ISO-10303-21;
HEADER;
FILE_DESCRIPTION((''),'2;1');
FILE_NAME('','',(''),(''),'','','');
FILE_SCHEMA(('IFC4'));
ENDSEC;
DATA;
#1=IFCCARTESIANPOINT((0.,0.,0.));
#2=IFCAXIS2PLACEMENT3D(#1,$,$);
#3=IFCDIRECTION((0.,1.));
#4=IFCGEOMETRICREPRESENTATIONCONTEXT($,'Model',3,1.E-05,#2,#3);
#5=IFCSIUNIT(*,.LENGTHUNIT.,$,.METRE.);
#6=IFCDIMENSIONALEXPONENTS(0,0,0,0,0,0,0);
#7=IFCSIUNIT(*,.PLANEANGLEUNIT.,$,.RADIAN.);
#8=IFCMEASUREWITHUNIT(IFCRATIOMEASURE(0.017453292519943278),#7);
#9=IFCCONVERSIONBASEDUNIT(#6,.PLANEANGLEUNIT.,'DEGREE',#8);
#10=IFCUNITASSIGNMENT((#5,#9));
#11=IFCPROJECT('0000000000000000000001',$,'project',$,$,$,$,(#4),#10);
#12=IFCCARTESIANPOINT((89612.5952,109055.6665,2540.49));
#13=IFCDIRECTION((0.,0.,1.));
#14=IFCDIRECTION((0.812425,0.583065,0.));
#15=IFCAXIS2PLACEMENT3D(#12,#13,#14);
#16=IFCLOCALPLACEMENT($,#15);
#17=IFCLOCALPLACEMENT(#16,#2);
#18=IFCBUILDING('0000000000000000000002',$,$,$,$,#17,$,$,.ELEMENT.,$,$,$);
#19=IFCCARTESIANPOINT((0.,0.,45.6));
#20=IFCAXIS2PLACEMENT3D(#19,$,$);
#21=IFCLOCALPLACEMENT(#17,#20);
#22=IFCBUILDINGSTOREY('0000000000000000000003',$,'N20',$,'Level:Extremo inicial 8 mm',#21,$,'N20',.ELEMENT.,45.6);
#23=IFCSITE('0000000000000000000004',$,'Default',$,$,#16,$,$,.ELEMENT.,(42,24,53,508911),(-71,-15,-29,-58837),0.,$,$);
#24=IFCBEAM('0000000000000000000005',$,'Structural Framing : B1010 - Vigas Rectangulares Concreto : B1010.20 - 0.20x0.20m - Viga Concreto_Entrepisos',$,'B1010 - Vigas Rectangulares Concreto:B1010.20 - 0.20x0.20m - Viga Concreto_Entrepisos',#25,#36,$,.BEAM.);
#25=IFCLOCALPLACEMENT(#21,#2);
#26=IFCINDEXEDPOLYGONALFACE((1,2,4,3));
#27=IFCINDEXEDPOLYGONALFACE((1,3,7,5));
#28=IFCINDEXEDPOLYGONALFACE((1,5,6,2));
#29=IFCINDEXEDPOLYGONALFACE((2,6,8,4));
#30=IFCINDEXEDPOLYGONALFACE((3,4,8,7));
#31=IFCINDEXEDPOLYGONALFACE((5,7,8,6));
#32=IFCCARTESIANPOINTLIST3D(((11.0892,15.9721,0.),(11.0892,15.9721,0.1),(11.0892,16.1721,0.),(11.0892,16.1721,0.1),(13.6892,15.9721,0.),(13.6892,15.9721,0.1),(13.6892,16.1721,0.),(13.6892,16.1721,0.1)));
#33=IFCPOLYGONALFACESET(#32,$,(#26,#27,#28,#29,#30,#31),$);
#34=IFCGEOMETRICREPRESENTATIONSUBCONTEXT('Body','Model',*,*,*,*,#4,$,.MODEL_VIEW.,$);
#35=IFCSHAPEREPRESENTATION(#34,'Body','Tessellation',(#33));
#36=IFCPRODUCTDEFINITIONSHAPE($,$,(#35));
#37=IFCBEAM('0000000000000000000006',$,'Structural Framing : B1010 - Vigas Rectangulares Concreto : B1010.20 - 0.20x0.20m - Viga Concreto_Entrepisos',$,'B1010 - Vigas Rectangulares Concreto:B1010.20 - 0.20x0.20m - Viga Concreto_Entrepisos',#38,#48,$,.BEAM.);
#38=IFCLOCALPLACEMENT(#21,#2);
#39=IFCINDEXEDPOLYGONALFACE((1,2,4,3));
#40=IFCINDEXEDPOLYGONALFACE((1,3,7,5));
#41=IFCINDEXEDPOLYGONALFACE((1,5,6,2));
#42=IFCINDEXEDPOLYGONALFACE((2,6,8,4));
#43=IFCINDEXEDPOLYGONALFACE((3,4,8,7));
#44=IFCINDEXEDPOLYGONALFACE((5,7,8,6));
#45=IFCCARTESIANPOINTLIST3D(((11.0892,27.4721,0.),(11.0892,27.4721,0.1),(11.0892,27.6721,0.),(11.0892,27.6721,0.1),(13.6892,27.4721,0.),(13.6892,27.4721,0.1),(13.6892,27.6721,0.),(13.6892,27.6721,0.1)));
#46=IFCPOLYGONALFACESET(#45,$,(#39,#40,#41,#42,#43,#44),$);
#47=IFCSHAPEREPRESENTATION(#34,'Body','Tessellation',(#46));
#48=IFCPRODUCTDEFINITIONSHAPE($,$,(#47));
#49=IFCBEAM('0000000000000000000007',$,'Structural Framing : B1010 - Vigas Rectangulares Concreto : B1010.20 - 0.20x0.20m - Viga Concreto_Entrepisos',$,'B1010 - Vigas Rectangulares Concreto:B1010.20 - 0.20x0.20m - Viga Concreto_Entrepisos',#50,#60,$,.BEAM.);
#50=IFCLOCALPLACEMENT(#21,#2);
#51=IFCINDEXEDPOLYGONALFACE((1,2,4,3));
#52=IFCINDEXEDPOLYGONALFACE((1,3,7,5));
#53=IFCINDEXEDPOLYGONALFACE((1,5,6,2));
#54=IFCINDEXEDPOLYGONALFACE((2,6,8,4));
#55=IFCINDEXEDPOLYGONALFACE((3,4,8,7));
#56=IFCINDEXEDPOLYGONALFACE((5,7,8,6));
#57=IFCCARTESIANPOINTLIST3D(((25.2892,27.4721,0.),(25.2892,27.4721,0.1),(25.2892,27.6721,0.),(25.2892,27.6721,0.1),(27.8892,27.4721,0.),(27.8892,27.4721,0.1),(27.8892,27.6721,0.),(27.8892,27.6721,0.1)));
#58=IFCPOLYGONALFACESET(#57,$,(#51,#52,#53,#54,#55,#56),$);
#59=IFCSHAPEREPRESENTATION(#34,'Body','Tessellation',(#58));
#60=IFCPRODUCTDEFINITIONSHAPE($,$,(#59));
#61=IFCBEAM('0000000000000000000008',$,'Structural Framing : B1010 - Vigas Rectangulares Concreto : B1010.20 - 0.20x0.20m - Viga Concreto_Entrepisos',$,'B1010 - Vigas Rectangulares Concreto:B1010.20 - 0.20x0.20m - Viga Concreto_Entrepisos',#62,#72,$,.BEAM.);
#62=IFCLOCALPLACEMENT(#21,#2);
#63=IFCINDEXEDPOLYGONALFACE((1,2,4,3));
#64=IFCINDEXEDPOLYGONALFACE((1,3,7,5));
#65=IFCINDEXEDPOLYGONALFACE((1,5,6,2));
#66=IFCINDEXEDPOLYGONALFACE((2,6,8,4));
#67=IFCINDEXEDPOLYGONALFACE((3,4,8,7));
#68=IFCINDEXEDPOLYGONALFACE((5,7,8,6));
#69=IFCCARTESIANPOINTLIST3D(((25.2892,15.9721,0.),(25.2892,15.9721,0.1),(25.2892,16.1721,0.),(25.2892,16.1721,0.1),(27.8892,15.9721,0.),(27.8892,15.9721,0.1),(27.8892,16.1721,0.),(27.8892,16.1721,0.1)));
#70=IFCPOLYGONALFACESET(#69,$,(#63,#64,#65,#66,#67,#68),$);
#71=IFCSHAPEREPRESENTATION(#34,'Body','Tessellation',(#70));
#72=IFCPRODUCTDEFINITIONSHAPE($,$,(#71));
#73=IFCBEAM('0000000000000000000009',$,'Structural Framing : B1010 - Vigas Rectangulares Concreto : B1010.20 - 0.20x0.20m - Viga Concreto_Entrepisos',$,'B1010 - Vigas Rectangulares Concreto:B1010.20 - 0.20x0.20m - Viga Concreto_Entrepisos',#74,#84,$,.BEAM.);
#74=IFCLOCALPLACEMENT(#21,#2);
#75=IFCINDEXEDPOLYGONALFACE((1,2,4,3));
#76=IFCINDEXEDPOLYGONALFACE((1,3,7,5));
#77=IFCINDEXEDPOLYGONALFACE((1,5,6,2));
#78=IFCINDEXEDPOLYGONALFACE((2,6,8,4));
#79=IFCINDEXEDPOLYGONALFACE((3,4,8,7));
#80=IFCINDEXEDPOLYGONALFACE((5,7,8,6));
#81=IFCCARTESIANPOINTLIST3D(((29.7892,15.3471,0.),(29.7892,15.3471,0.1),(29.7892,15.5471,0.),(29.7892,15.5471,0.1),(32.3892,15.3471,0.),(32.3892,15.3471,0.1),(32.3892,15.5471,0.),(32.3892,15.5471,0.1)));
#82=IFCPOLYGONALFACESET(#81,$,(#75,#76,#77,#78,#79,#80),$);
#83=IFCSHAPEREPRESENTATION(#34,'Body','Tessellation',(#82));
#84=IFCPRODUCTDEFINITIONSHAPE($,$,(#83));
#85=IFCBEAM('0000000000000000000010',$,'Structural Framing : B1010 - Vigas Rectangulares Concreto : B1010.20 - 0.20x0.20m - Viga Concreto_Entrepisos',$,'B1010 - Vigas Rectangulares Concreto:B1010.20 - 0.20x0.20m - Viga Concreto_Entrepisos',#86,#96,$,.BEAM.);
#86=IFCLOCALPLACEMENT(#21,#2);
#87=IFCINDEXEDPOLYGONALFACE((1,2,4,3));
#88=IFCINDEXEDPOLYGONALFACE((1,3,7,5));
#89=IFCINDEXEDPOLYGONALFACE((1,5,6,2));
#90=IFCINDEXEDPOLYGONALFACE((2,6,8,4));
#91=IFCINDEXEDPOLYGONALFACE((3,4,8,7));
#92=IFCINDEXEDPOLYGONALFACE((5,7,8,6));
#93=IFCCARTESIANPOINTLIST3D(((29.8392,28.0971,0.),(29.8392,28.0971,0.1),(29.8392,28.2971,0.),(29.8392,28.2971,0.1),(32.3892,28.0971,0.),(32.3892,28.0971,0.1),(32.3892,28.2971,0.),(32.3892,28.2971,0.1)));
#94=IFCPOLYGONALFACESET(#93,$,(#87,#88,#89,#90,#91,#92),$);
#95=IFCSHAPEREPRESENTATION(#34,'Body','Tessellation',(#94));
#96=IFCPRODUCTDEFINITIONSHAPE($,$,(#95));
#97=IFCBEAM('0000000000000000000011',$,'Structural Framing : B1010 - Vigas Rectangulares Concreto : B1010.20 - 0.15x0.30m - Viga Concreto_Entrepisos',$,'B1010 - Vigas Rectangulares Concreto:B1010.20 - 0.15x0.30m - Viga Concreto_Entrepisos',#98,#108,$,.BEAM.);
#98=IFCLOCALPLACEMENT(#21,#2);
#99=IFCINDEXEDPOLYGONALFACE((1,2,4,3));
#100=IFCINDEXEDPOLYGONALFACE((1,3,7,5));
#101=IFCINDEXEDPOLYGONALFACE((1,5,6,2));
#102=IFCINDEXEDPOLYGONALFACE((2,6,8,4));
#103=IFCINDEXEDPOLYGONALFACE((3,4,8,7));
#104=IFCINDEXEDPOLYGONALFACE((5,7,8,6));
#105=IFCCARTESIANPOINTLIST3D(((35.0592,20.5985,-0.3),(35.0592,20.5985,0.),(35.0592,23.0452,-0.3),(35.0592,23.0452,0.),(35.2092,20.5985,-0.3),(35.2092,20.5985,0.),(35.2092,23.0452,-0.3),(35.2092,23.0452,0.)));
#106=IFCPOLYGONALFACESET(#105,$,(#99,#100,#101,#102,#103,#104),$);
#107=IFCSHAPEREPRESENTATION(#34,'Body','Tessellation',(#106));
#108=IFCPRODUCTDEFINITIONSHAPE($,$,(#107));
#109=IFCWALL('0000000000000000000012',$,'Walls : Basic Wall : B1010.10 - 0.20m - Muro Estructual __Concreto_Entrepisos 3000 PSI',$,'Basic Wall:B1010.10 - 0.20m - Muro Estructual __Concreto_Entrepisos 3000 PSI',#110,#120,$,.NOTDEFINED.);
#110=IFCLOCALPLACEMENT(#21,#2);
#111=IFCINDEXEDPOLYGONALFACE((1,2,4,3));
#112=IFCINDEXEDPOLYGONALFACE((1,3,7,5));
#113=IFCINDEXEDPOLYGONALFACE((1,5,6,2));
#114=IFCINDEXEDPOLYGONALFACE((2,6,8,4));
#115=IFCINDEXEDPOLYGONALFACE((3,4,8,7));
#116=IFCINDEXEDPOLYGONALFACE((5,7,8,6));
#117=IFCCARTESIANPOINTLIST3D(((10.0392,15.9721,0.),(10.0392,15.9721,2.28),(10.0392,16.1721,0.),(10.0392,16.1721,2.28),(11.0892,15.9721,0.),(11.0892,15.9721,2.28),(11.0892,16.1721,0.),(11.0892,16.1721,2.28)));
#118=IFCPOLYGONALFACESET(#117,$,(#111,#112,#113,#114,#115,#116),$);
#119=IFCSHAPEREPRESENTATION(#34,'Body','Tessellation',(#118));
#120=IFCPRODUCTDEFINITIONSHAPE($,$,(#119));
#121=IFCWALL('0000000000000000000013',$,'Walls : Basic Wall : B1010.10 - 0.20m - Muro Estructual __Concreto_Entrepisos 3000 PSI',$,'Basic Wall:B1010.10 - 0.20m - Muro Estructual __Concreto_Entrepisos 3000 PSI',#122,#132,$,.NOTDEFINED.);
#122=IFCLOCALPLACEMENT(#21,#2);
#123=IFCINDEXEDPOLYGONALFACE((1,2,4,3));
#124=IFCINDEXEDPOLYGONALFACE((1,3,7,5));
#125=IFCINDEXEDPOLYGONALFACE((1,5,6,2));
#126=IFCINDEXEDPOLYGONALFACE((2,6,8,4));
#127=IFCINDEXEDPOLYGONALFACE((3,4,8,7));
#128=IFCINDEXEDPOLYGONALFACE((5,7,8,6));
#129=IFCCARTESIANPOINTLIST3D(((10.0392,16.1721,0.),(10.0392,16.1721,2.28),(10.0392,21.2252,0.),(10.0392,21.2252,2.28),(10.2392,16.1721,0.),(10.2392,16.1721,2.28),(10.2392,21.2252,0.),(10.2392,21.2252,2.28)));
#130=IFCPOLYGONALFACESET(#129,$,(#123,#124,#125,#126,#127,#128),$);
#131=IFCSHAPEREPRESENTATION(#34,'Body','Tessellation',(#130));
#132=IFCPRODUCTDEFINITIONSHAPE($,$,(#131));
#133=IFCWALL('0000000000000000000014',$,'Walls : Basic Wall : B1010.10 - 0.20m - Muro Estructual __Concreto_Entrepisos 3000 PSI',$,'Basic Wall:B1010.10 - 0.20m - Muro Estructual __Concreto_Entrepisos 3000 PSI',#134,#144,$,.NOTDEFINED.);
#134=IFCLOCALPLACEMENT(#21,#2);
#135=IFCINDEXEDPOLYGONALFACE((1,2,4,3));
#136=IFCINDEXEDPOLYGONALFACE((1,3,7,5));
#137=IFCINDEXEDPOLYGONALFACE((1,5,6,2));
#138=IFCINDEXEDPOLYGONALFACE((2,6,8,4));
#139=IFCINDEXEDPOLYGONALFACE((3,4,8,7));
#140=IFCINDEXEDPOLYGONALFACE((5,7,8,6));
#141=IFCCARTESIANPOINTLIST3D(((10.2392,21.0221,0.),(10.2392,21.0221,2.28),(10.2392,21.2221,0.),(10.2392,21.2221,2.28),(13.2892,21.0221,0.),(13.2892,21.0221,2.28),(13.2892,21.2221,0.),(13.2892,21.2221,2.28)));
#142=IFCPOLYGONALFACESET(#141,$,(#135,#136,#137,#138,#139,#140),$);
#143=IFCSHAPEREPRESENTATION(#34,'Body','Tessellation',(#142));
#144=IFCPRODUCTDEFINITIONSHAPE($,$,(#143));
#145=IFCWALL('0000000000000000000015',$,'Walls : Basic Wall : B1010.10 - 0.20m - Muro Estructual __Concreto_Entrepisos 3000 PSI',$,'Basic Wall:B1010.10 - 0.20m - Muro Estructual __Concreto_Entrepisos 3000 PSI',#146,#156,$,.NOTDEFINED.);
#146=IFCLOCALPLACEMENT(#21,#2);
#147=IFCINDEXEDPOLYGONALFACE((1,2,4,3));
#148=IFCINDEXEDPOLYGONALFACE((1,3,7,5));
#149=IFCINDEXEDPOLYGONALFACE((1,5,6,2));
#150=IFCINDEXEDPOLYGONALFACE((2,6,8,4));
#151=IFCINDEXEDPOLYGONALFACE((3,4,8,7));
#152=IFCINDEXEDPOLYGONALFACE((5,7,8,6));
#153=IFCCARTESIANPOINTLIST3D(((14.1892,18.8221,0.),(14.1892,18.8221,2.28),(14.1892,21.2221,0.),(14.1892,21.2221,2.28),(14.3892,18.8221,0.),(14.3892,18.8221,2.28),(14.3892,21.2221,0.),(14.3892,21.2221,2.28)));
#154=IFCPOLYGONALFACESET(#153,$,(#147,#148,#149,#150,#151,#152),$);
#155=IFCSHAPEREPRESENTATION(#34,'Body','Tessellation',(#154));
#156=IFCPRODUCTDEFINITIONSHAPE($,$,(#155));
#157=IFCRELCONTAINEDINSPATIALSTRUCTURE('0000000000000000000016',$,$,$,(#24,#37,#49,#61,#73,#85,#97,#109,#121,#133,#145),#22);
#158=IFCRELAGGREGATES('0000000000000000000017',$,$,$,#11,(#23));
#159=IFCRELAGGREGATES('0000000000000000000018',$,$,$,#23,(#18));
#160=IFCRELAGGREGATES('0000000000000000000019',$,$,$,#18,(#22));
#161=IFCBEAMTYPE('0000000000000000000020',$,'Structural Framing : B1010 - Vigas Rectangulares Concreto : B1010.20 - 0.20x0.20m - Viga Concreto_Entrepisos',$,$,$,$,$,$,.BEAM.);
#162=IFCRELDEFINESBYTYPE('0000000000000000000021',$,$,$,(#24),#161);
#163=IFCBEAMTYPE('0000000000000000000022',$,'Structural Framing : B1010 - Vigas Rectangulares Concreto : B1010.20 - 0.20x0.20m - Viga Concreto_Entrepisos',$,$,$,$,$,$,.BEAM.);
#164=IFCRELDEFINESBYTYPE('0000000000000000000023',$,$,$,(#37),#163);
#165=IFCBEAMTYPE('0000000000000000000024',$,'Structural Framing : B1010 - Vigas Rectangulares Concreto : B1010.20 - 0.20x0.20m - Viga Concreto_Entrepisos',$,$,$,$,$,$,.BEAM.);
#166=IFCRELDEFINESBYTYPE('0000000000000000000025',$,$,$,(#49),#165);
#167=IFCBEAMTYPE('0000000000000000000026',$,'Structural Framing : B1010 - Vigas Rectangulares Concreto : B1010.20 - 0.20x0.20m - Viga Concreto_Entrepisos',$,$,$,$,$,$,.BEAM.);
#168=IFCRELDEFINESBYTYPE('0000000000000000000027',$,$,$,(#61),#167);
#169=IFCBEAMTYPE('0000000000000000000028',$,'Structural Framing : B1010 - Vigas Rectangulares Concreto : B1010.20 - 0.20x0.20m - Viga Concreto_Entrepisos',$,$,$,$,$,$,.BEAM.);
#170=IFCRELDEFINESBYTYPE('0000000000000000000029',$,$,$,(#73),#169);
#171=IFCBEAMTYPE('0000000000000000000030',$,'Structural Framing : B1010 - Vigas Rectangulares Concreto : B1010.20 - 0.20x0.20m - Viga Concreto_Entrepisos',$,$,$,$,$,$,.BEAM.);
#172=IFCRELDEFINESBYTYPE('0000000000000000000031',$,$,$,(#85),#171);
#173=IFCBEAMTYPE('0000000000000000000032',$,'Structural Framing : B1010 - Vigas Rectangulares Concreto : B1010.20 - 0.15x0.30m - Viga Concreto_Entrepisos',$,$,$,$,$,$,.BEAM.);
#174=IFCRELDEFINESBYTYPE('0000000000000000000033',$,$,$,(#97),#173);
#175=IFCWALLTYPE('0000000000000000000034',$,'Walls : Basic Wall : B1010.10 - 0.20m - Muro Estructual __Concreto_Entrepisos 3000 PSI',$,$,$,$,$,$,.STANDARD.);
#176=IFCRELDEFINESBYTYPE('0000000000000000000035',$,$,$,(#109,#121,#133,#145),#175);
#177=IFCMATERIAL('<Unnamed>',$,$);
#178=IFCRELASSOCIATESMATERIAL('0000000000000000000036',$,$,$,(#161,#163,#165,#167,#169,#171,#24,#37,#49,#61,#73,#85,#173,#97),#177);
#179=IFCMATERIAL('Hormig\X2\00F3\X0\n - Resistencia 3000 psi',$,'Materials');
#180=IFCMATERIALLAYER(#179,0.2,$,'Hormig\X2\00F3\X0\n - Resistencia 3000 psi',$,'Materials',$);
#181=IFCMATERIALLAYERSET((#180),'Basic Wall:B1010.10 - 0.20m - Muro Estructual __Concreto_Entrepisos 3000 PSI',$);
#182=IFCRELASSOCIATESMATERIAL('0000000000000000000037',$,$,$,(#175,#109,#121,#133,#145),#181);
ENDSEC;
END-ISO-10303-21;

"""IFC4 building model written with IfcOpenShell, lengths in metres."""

from ifc_helpers import new_model, entity, si_unit, converted_unit, direction, frame, frame_2d, origin, place, context, subcontext, project, spatial, polyline, segment, composite_curve, rectangle, outline, extrude, source, transform, mapped, material, layer, layer_set, layer_usage, material_profile, profile_set, profile_usage, type_object, type_shapes, element, save


model = new_model("IFC4")

# Units and contexts
model_context = context("Model", 3, precision=1e-05, world=origin(), true_north=direction((0.0, 1.0)))
body_context = subcontext(model_context, "Body", "Model", "MODEL_VIEW")
ifc_project = project(units=[si_unit("LENGTHUNIT", "METRE"), converted_unit("PLANEANGLEUNIT", "DEGREE", entity("IfcRatioMeasure", 0.017453292519943278), si_unit("PLANEANGLEUNIT", "RADIAN"), dimensions=[0, 0, 0, 0, 0, 0, 0])], contexts=[model_context])

# Site, building, storey
site_placement = place(None, frame((89612.5952, 109055.6665, 2540.49), z_axis=(0.0, 0.0, 1.0), x_axis=(0.812425, 0.583065, 0.0)))
site = spatial("IfcSite", under=ifc_project, at=site_placement, Name="Default", CompositionType="ELEMENT", RefLatitude=(42, 24, 53, 508911), RefLongitude=(-71, -15, -29, -58837), RefElevation=0.0)
building_placement = place(site_placement, origin())
building = spatial("IfcBuilding", under=site, at=building_placement, CompositionType="ELEMENT")
storey_placement = place(building_placement, frame((0.0, 0.0, 45.6)))
storey = spatial("IfcBuildingStorey", under=building, at=storey_placement, Name="N20", ObjectType="Level:Extremo inicial 8 mm", LongName="N20", CompositionType="ELEMENT", Elevation=45.6)

# Beams
ifc_material_1 = material(Name="<Unnamed>")
ifc_material_profile_1 = material_profile(ifc_material_1, outline(composite_curve([segment(polyline([(-0.1, 0.0, 0.0), (-0.1, 0.1, 0.0)]), True, "CONTINUOUS"), segment(polyline([(-0.1, 0.1, 0.0), (0.1, 0.1, 0.0)]), True, "CONTINUOUS"), segment(polyline([(0.1, 0.1, 0.0), (0.1, 0.0, 0.0)]), True, "CONTINUOUS"), segment(polyline([(0.1, 0.0, 0.0), (-0.1, 0.0, 0.0)]), True, "CONTINUOUS")], self_intersect=False), kind="CURVE"), Name="B1010.20 - 0.20x0.20m - Viga Concreto_Entrepisos")
ifc_material_profile_2 = material_profile(ifc_material_1, outline(composite_curve([segment(polyline([(-1.3, -0.1, 0.1), (-1.3, 0.1, 0.1)]), True, "CONTINUOUS"), segment(polyline([(-1.3, 0.1, 0.1), (-1.3, 0.1, -0.1)]), True, "CONTINUOUS"), segment(polyline([(-1.3, 0.1, -0.1), (-1.3, -0.1, -0.1)]), True, "CONTINUOUS"), segment(polyline([(-1.3, -0.1, -0.1), (-1.3, -0.1, 0.1)]), True, "CONTINUOUS")], self_intersect=False), kind="CURVE"), Name="B1010.20 - 0.20x0.20m - Viga Concreto_Entrepisos")
ifc_profile_set_1 = profile_set([ifc_material_profile_1, ifc_material_profile_2], Name="B1010.20 - 0.20x0.20m - Viga Concreto_Entrepisos")
ifc_profile_usage_1 = profile_usage(ifc_profile_set_1, cardinal=8)
beam_type_1 = type_object("IfcBeamType", Name="Structural Framing : B1010 - Vigas Rectangulares Concreto : B1010.20 - 0.20x0.20m - Viga Concreto_Entrepisos", PredefinedType="BEAM", material=ifc_profile_set_1)
shared_shape_1 = source(origin(), body_context, "Body", "SweptSolid", [
    extrude(rectangle(XDim=0.1, YDim=0.2, at=frame_2d((0.0, 0.0), x_axis=(1.0, 0.0))), frame((13.6892, 16.0721, 45.65), z_axis=(-1.0, 0.0, 0.0), x_axis=(0.0, 0.0, -1.0)), (0.0, 0.0, 1.0), 2.6),
])
type_shapes(beam_type_1, [shared_shape_1])
beam_1_placement = place(storey_placement, frame((0.0, 0.0, -45.6)))
element("IfcBeam", 1, at=beam_1_placement, inside=storey, type_object=beam_type_1, material=ifc_profile_usage_1, Name="Structural Framing : B1010 - Vigas Rectangulares Concreto : B1010.20 - 0.20x0.20m - Viga Concreto_Entrepisos", ObjectType="B1010 - Vigas Rectangulares Concreto:B1010.20 - 0.20x0.20m - Viga Concreto_Entrepisos", PredefinedType="BEAM", context=body_context, shape_type="MappedRepresentation", body=[
    mapped(shared_shape_1, transform((0.0, 0.0, 0.0), scale=1.0)),
])
ifc_profile_usage_2 = profile_usage(ifc_profile_set_1, cardinal=8)
beam_type_2 = type_object("IfcBeamType", Name="Structural Framing : B1010 - Vigas Rectangulares Concreto : B1010.20 - 0.20x0.20m - Viga Concreto_Entrepisos", PredefinedType="BEAM", material=ifc_profile_set_1)
shared_shape_2 = source(origin(), body_context, "Body", "SweptSolid", [
    extrude(rectangle(XDim=0.1, YDim=0.2, at=frame_2d((0.0, 0.0), x_axis=(1.0, 0.0))), frame((13.6892, 27.5721, 45.65), z_axis=(-1.0, 0.0, 0.0), x_axis=(0.0, 0.0, -1.0)), (0.0, 0.0, 1.0), 2.6),
])
type_shapes(beam_type_2, [shared_shape_2])
beam_2_placement = place(storey_placement, frame((0.0, 0.0, -45.6)))
element("IfcBeam", 2, at=beam_2_placement, inside=storey, type_object=beam_type_2, material=ifc_profile_usage_2, Name="Structural Framing : B1010 - Vigas Rectangulares Concreto : B1010.20 - 0.20x0.20m - Viga Concreto_Entrepisos", ObjectType="B1010 - Vigas Rectangulares Concreto:B1010.20 - 0.20x0.20m - Viga Concreto_Entrepisos", PredefinedType="BEAM", context=body_context, shape_type="MappedRepresentation", body=[
    mapped(shared_shape_2, transform((0.0, 0.0, 0.0), scale=1.0)),
])
ifc_profile_usage_3 = profile_usage(ifc_profile_set_1, cardinal=8)
beam_type_3 = type_object("IfcBeamType", Name="Structural Framing : B1010 - Vigas Rectangulares Concreto : B1010.20 - 0.20x0.20m - Viga Concreto_Entrepisos", PredefinedType="BEAM", material=ifc_profile_set_1)
shared_shape_3 = source(origin(), body_context, "Body", "SweptSolid", [
    extrude(rectangle(XDim=0.1, YDim=0.2, at=frame_2d((0.0, 0.0), x_axis=(1.0, 0.0))), frame((25.2892, 27.5721, 45.65), z_axis=(1.0, 0.0, 0.0), x_axis=(0.0, 0.0, -1.0)), (0.0, 0.0, 1.0), 2.6),
])
type_shapes(beam_type_3, [shared_shape_3])
beam_3_placement = place(storey_placement, frame((0.0, 0.0, -45.6)))
element("IfcBeam", 3, at=beam_3_placement, inside=storey, type_object=beam_type_3, material=ifc_profile_usage_3, Name="Structural Framing : B1010 - Vigas Rectangulares Concreto : B1010.20 - 0.20x0.20m - Viga Concreto_Entrepisos", ObjectType="B1010 - Vigas Rectangulares Concreto:B1010.20 - 0.20x0.20m - Viga Concreto_Entrepisos", PredefinedType="BEAM", context=body_context, shape_type="MappedRepresentation", body=[
    mapped(shared_shape_3, transform((0.0, 0.0, 0.0), scale=1.0)),
])
ifc_profile_usage_4 = profile_usage(ifc_profile_set_1, cardinal=8)
beam_type_4 = type_object("IfcBeamType", Name="Structural Framing : B1010 - Vigas Rectangulares Concreto : B1010.20 - 0.20x0.20m - Viga Concreto_Entrepisos", PredefinedType="BEAM", material=ifc_profile_set_1)
shared_shape_4 = source(origin(), body_context, "Body", "SweptSolid", [
    extrude(rectangle(XDim=0.1, YDim=0.2, at=frame_2d((0.0, 0.0), x_axis=(1.0, 0.0))), frame((25.2892, 16.0721, 45.65), z_axis=(1.0, 0.0, 0.0), x_axis=(0.0, 0.0, -1.0)), (0.0, 0.0, 1.0), 2.6),
])
type_shapes(beam_type_4, [shared_shape_4])
beam_4_placement = place(storey_placement, frame((0.0, 0.0, -45.6)))
element("IfcBeam", 4, at=beam_4_placement, inside=storey, type_object=beam_type_4, material=ifc_profile_usage_4, Name="Structural Framing : B1010 - Vigas Rectangulares Concreto : B1010.20 - 0.20x0.20m - Viga Concreto_Entrepisos", ObjectType="B1010 - Vigas Rectangulares Concreto:B1010.20 - 0.20x0.20m - Viga Concreto_Entrepisos", PredefinedType="BEAM", context=body_context, shape_type="MappedRepresentation", body=[
    mapped(shared_shape_4, transform((0.0, 0.0, 0.0), scale=1.0)),
])
ifc_profile_usage_5 = profile_usage(ifc_profile_set_1, cardinal=8)
beam_type_5 = type_object("IfcBeamType", Name="Structural Framing : B1010 - Vigas Rectangulares Concreto : B1010.20 - 0.20x0.20m - Viga Concreto_Entrepisos", PredefinedType="BEAM", material=ifc_profile_set_1)
shared_shape_5 = source(origin(), body_context, "Body", "SweptSolid", [
    extrude(rectangle(XDim=0.1, YDim=0.2, at=frame_2d((0.0, 0.0), x_axis=(1.0, 0.0))), frame((32.3892, 15.4471, 45.65), z_axis=(-1.0, 0.0, 0.0), x_axis=(0.0, 0.0, -1.0)), (0.0, 0.0, 1.0), 2.6),
])
type_shapes(beam_type_5, [shared_shape_5])
beam_5_placement = place(storey_placement, frame((0.0, 0.0, -45.6)))
element("IfcBeam", 5, at=beam_5_placement, inside=storey, type_object=beam_type_5, material=ifc_profile_usage_5, Name="Structural Framing : B1010 - Vigas Rectangulares Concreto : B1010.20 - 0.20x0.20m - Viga Concreto_Entrepisos", ObjectType="B1010 - Vigas Rectangulares Concreto:B1010.20 - 0.20x0.20m - Viga Concreto_Entrepisos", PredefinedType="BEAM", context=body_context, shape_type="MappedRepresentation", body=[
    mapped(shared_shape_5, transform((0.0, 0.0, 0.0), scale=1.0)),
])
ifc_profile_usage_6 = profile_usage(ifc_profile_set_1, cardinal=8)
beam_type_6 = type_object("IfcBeamType", Name="Structural Framing : B1010 - Vigas Rectangulares Concreto : B1010.20 - 0.20x0.20m - Viga Concreto_Entrepisos", PredefinedType="BEAM", material=ifc_profile_set_1)
shared_shape_6 = source(origin(), body_context, "Body", "SweptSolid", [
    extrude(rectangle(XDim=0.1, YDim=0.2, at=frame_2d((0.0, 0.0), x_axis=(1.0, 0.0))), frame((29.8392, 28.1971, 45.65), z_axis=(1.0, 0.0, 0.0), x_axis=(0.0, 0.0, -1.0)), (0.0, 0.0, 1.0), 2.55),
])
type_shapes(beam_type_6, [shared_shape_6])
beam_6_placement = place(storey_placement, frame((0.0, 0.0, -45.6)))
element("IfcBeam", 6, at=beam_6_placement, inside=storey, type_object=beam_type_6, material=ifc_profile_usage_6, Name="Structural Framing : B1010 - Vigas Rectangulares Concreto : B1010.20 - 0.20x0.20m - Viga Concreto_Entrepisos", ObjectType="B1010 - Vigas Rectangulares Concreto:B1010.20 - 0.20x0.20m - Viga Concreto_Entrepisos", PredefinedType="BEAM", context=body_context, shape_type="MappedRepresentation", body=[
    mapped(shared_shape_6, transform((0.0, 0.0, 0.0), scale=1.0)),
])
ifc_material_profile_3 = material_profile(ifc_material_1, outline(composite_curve([segment(polyline([(-0.075, -0.15, 0.0), (-0.075, 0.15, 0.0)]), True, "CONTINUOUS"), segment(polyline([(-0.075, 0.15, 0.0), (0.075, 0.15, 0.0)]), True, "CONTINUOUS"), segment(polyline([(0.075, 0.15, 0.0), (0.075, -0.15, 0.0)]), True, "CONTINUOUS"), segment(polyline([(0.075, -0.15, 0.0), (-0.075, -0.15, 0.0)]), True, "CONTINUOUS")], self_intersect=False), kind="CURVE"), Name="B1010.20 - 0.15x0.30m - Viga Concreto_Entrepisos")
ifc_material_profile_4 = material_profile(ifc_material_1, outline(composite_curve([segment(polyline([(1.2233, 0.075, 0.15), (1.2233, 0.075, -0.15)]), True, "CONTINUOUS"), segment(polyline([(1.2233, 0.075, -0.15), (-1.2233, 0.075, -0.15)]), True, "CONTINUOUS"), segment(polyline([(-1.2233, 0.075, -0.15), (-1.2233, 0.075, 0.15)]), True, "CONTINUOUS"), segment(polyline([(-1.2233, 0.075, 0.15), (1.2233, 0.075, 0.15)]), True, "CONTINUOUS")], self_intersect=False), kind="CURVE"), Name="B1010.20 - 0.15x0.30m - Viga Concreto_Entrepisos")
ifc_profile_set_2 = profile_set([ifc_material_profile_3, ifc_material_profile_4], Name="B1010.20 - 0.15x0.30m - Viga Concreto_Entrepisos")
ifc_profile_usage_7 = profile_usage(ifc_profile_set_2, cardinal=8)
beam_type_7 = type_object("IfcBeamType", Name="Structural Framing : B1010 - Vigas Rectangulares Concreto : B1010.20 - 0.15x0.30m - Viga Concreto_Entrepisos", PredefinedType="BEAM", material=ifc_profile_set_2)
shared_shape_7 = source(origin(), body_context, "Body", "SweptSolid", [
    extrude(rectangle(XDim=0.3, YDim=0.15, at=frame_2d((0.0, 0.0), x_axis=(0.0, 1.0))), frame((35.1342, 20.5985, 45.45), z_axis=(0.0, 1.0, 0.0), x_axis=(-1.0, 0.0, 0.0)), (0.0, 0.0, 1.0), 2.4467),
])
type_shapes(beam_type_7, [shared_shape_7])
beam_7_placement = place(storey_placement, frame((0.0, 0.0, -45.6)))
element("IfcBeam", 7, at=beam_7_placement, inside=storey, type_object=beam_type_7, material=ifc_profile_usage_7, Name="Structural Framing : B1010 - Vigas Rectangulares Concreto : B1010.20 - 0.15x0.30m - Viga Concreto_Entrepisos", ObjectType="B1010 - Vigas Rectangulares Concreto:B1010.20 - 0.15x0.30m - Viga Concreto_Entrepisos", PredefinedType="BEAM", context=body_context, shape_type="MappedRepresentation", body=[
    mapped(shared_shape_7, transform((0.0, 0.0, 0.0), scale=1.0)),
])

# Walls
ifc_material_2 = material(Name="Hormigón - Resistencia 3000 psi", Category="Materials")
ifc_layer_1 = layer(ifc_material_2, 0.2, Name="Hormigón - Resistencia 3000 psi", Category="Materials")
ifc_layer_set_1 = layer_set([ifc_layer_1], Name="Basic Wall:B1010.10 - 0.20m - Muro Estructual __Concreto_Entrepisos 3000 PSI")
ifc_layer_usage_1 = layer_usage(ifc_layer_set_1, "AXIS2", "NEGATIVE", 0.1)
wall_type_1 = type_object("IfcWallType", Name="Walls : Basic Wall : B1010.10 - 0.20m - Muro Estructual __Concreto_Entrepisos 3000 PSI", PredefinedType="STANDARD", material=ifc_layer_set_1)
wall_1_placement = place(storey_placement, frame((11.0892, 16.0721, 0.0), z_axis=(0.0, 0.0, 1.0), x_axis=(-1.0, 0.0, 0.0)))
element("IfcWall", 8, at=wall_1_placement, inside=storey, type_object=wall_type_1, material=ifc_layer_usage_1, Name="Walls : Basic Wall : B1010.10 - 0.20m - Muro Estructual __Concreto_Entrepisos 3000 PSI", ObjectType="Basic Wall:B1010.10 - 0.20m - Muro Estructual __Concreto_Entrepisos 3000 PSI", PredefinedType="NOTDEFINED", context=body_context, shape_type="SweptSolid", body=[
    extrude(rectangle(XDim=1.05, YDim=0.2, at=frame_2d((0.525, 0.0), x_axis=(-1.0, 0.0))), origin(), (0.0, 0.0, 1.0), 2.28),
])
ifc_layer_usage_2 = layer_usage(ifc_layer_set_1, "AXIS2", "NEGATIVE", 0.1)
wall_2_placement = place(storey_placement, frame((10.1392, 16.1721, 0.0), z_axis=(0.0, 0.0, 1.0), x_axis=(0.0, 1.0, 0.0)))
element("IfcWall", 9, at=wall_2_placement, inside=storey, type_object=wall_type_1, material=ifc_layer_usage_2, Name="Walls : Basic Wall : B1010.10 - 0.20m - Muro Estructual __Concreto_Entrepisos 3000 PSI", ObjectType="Basic Wall:B1010.10 - 0.20m - Muro Estructual __Concreto_Entrepisos 3000 PSI", PredefinedType="NOTDEFINED", context=body_context, shape_type="SweptSolid", body=[
    extrude(rectangle(XDim=5.0531, YDim=0.2, at=frame_2d((2.5265, 0.0), x_axis=(-1.0, 0.0))), origin(), (0.0, 0.0, 1.0), 2.28),
])
ifc_layer_usage_3 = layer_usage(ifc_layer_set_1, "AXIS2", "NEGATIVE", 0.1)
wall_3_placement = place(storey_placement, frame((10.2392, 21.1221, 0.0)))
element("IfcWall", 10, at=wall_3_placement, inside=storey, type_object=wall_type_1, material=ifc_layer_usage_3, Name="Walls : Basic Wall : B1010.10 - 0.20m - Muro Estructual __Concreto_Entrepisos 3000 PSI", ObjectType="Basic Wall:B1010.10 - 0.20m - Muro Estructual __Concreto_Entrepisos 3000 PSI", PredefinedType="NOTDEFINED", context=body_context, shape_type="SweptSolid", body=[
    extrude(rectangle(XDim=3.05, YDim=0.2, at=frame_2d((1.525, 0.0), x_axis=(-1.0, 0.0))), origin(), (0.0, 0.0, 1.0), 2.28),
])
ifc_layer_usage_4 = layer_usage(ifc_layer_set_1, "AXIS2", "NEGATIVE", 0.1)
wall_4_placement = place(storey_placement, frame((14.2892, 18.8221, 0.0), z_axis=(0.0, 0.0, 1.0), x_axis=(0.0, 1.0, 0.0)))
element("IfcWall", 11, at=wall_4_placement, inside=storey, type_object=wall_type_1, material=ifc_layer_usage_4, Name="Walls : Basic Wall : B1010.10 - 0.20m - Muro Estructual __Concreto_Entrepisos 3000 PSI", ObjectType="Basic Wall:B1010.10 - 0.20m - Muro Estructual __Concreto_Entrepisos 3000 PSI", PredefinedType="NOTDEFINED", context=body_context, shape_type="SweptSolid", body=[
    extrude(rectangle(XDim=2.4, YDim=0.2, at=frame_2d((1.2, 0.0), x_axis=(-1.0, 0.0))), origin(), (0.0, 0.0, 1.0), 2.28),
])

save(model, "model.ifc")
